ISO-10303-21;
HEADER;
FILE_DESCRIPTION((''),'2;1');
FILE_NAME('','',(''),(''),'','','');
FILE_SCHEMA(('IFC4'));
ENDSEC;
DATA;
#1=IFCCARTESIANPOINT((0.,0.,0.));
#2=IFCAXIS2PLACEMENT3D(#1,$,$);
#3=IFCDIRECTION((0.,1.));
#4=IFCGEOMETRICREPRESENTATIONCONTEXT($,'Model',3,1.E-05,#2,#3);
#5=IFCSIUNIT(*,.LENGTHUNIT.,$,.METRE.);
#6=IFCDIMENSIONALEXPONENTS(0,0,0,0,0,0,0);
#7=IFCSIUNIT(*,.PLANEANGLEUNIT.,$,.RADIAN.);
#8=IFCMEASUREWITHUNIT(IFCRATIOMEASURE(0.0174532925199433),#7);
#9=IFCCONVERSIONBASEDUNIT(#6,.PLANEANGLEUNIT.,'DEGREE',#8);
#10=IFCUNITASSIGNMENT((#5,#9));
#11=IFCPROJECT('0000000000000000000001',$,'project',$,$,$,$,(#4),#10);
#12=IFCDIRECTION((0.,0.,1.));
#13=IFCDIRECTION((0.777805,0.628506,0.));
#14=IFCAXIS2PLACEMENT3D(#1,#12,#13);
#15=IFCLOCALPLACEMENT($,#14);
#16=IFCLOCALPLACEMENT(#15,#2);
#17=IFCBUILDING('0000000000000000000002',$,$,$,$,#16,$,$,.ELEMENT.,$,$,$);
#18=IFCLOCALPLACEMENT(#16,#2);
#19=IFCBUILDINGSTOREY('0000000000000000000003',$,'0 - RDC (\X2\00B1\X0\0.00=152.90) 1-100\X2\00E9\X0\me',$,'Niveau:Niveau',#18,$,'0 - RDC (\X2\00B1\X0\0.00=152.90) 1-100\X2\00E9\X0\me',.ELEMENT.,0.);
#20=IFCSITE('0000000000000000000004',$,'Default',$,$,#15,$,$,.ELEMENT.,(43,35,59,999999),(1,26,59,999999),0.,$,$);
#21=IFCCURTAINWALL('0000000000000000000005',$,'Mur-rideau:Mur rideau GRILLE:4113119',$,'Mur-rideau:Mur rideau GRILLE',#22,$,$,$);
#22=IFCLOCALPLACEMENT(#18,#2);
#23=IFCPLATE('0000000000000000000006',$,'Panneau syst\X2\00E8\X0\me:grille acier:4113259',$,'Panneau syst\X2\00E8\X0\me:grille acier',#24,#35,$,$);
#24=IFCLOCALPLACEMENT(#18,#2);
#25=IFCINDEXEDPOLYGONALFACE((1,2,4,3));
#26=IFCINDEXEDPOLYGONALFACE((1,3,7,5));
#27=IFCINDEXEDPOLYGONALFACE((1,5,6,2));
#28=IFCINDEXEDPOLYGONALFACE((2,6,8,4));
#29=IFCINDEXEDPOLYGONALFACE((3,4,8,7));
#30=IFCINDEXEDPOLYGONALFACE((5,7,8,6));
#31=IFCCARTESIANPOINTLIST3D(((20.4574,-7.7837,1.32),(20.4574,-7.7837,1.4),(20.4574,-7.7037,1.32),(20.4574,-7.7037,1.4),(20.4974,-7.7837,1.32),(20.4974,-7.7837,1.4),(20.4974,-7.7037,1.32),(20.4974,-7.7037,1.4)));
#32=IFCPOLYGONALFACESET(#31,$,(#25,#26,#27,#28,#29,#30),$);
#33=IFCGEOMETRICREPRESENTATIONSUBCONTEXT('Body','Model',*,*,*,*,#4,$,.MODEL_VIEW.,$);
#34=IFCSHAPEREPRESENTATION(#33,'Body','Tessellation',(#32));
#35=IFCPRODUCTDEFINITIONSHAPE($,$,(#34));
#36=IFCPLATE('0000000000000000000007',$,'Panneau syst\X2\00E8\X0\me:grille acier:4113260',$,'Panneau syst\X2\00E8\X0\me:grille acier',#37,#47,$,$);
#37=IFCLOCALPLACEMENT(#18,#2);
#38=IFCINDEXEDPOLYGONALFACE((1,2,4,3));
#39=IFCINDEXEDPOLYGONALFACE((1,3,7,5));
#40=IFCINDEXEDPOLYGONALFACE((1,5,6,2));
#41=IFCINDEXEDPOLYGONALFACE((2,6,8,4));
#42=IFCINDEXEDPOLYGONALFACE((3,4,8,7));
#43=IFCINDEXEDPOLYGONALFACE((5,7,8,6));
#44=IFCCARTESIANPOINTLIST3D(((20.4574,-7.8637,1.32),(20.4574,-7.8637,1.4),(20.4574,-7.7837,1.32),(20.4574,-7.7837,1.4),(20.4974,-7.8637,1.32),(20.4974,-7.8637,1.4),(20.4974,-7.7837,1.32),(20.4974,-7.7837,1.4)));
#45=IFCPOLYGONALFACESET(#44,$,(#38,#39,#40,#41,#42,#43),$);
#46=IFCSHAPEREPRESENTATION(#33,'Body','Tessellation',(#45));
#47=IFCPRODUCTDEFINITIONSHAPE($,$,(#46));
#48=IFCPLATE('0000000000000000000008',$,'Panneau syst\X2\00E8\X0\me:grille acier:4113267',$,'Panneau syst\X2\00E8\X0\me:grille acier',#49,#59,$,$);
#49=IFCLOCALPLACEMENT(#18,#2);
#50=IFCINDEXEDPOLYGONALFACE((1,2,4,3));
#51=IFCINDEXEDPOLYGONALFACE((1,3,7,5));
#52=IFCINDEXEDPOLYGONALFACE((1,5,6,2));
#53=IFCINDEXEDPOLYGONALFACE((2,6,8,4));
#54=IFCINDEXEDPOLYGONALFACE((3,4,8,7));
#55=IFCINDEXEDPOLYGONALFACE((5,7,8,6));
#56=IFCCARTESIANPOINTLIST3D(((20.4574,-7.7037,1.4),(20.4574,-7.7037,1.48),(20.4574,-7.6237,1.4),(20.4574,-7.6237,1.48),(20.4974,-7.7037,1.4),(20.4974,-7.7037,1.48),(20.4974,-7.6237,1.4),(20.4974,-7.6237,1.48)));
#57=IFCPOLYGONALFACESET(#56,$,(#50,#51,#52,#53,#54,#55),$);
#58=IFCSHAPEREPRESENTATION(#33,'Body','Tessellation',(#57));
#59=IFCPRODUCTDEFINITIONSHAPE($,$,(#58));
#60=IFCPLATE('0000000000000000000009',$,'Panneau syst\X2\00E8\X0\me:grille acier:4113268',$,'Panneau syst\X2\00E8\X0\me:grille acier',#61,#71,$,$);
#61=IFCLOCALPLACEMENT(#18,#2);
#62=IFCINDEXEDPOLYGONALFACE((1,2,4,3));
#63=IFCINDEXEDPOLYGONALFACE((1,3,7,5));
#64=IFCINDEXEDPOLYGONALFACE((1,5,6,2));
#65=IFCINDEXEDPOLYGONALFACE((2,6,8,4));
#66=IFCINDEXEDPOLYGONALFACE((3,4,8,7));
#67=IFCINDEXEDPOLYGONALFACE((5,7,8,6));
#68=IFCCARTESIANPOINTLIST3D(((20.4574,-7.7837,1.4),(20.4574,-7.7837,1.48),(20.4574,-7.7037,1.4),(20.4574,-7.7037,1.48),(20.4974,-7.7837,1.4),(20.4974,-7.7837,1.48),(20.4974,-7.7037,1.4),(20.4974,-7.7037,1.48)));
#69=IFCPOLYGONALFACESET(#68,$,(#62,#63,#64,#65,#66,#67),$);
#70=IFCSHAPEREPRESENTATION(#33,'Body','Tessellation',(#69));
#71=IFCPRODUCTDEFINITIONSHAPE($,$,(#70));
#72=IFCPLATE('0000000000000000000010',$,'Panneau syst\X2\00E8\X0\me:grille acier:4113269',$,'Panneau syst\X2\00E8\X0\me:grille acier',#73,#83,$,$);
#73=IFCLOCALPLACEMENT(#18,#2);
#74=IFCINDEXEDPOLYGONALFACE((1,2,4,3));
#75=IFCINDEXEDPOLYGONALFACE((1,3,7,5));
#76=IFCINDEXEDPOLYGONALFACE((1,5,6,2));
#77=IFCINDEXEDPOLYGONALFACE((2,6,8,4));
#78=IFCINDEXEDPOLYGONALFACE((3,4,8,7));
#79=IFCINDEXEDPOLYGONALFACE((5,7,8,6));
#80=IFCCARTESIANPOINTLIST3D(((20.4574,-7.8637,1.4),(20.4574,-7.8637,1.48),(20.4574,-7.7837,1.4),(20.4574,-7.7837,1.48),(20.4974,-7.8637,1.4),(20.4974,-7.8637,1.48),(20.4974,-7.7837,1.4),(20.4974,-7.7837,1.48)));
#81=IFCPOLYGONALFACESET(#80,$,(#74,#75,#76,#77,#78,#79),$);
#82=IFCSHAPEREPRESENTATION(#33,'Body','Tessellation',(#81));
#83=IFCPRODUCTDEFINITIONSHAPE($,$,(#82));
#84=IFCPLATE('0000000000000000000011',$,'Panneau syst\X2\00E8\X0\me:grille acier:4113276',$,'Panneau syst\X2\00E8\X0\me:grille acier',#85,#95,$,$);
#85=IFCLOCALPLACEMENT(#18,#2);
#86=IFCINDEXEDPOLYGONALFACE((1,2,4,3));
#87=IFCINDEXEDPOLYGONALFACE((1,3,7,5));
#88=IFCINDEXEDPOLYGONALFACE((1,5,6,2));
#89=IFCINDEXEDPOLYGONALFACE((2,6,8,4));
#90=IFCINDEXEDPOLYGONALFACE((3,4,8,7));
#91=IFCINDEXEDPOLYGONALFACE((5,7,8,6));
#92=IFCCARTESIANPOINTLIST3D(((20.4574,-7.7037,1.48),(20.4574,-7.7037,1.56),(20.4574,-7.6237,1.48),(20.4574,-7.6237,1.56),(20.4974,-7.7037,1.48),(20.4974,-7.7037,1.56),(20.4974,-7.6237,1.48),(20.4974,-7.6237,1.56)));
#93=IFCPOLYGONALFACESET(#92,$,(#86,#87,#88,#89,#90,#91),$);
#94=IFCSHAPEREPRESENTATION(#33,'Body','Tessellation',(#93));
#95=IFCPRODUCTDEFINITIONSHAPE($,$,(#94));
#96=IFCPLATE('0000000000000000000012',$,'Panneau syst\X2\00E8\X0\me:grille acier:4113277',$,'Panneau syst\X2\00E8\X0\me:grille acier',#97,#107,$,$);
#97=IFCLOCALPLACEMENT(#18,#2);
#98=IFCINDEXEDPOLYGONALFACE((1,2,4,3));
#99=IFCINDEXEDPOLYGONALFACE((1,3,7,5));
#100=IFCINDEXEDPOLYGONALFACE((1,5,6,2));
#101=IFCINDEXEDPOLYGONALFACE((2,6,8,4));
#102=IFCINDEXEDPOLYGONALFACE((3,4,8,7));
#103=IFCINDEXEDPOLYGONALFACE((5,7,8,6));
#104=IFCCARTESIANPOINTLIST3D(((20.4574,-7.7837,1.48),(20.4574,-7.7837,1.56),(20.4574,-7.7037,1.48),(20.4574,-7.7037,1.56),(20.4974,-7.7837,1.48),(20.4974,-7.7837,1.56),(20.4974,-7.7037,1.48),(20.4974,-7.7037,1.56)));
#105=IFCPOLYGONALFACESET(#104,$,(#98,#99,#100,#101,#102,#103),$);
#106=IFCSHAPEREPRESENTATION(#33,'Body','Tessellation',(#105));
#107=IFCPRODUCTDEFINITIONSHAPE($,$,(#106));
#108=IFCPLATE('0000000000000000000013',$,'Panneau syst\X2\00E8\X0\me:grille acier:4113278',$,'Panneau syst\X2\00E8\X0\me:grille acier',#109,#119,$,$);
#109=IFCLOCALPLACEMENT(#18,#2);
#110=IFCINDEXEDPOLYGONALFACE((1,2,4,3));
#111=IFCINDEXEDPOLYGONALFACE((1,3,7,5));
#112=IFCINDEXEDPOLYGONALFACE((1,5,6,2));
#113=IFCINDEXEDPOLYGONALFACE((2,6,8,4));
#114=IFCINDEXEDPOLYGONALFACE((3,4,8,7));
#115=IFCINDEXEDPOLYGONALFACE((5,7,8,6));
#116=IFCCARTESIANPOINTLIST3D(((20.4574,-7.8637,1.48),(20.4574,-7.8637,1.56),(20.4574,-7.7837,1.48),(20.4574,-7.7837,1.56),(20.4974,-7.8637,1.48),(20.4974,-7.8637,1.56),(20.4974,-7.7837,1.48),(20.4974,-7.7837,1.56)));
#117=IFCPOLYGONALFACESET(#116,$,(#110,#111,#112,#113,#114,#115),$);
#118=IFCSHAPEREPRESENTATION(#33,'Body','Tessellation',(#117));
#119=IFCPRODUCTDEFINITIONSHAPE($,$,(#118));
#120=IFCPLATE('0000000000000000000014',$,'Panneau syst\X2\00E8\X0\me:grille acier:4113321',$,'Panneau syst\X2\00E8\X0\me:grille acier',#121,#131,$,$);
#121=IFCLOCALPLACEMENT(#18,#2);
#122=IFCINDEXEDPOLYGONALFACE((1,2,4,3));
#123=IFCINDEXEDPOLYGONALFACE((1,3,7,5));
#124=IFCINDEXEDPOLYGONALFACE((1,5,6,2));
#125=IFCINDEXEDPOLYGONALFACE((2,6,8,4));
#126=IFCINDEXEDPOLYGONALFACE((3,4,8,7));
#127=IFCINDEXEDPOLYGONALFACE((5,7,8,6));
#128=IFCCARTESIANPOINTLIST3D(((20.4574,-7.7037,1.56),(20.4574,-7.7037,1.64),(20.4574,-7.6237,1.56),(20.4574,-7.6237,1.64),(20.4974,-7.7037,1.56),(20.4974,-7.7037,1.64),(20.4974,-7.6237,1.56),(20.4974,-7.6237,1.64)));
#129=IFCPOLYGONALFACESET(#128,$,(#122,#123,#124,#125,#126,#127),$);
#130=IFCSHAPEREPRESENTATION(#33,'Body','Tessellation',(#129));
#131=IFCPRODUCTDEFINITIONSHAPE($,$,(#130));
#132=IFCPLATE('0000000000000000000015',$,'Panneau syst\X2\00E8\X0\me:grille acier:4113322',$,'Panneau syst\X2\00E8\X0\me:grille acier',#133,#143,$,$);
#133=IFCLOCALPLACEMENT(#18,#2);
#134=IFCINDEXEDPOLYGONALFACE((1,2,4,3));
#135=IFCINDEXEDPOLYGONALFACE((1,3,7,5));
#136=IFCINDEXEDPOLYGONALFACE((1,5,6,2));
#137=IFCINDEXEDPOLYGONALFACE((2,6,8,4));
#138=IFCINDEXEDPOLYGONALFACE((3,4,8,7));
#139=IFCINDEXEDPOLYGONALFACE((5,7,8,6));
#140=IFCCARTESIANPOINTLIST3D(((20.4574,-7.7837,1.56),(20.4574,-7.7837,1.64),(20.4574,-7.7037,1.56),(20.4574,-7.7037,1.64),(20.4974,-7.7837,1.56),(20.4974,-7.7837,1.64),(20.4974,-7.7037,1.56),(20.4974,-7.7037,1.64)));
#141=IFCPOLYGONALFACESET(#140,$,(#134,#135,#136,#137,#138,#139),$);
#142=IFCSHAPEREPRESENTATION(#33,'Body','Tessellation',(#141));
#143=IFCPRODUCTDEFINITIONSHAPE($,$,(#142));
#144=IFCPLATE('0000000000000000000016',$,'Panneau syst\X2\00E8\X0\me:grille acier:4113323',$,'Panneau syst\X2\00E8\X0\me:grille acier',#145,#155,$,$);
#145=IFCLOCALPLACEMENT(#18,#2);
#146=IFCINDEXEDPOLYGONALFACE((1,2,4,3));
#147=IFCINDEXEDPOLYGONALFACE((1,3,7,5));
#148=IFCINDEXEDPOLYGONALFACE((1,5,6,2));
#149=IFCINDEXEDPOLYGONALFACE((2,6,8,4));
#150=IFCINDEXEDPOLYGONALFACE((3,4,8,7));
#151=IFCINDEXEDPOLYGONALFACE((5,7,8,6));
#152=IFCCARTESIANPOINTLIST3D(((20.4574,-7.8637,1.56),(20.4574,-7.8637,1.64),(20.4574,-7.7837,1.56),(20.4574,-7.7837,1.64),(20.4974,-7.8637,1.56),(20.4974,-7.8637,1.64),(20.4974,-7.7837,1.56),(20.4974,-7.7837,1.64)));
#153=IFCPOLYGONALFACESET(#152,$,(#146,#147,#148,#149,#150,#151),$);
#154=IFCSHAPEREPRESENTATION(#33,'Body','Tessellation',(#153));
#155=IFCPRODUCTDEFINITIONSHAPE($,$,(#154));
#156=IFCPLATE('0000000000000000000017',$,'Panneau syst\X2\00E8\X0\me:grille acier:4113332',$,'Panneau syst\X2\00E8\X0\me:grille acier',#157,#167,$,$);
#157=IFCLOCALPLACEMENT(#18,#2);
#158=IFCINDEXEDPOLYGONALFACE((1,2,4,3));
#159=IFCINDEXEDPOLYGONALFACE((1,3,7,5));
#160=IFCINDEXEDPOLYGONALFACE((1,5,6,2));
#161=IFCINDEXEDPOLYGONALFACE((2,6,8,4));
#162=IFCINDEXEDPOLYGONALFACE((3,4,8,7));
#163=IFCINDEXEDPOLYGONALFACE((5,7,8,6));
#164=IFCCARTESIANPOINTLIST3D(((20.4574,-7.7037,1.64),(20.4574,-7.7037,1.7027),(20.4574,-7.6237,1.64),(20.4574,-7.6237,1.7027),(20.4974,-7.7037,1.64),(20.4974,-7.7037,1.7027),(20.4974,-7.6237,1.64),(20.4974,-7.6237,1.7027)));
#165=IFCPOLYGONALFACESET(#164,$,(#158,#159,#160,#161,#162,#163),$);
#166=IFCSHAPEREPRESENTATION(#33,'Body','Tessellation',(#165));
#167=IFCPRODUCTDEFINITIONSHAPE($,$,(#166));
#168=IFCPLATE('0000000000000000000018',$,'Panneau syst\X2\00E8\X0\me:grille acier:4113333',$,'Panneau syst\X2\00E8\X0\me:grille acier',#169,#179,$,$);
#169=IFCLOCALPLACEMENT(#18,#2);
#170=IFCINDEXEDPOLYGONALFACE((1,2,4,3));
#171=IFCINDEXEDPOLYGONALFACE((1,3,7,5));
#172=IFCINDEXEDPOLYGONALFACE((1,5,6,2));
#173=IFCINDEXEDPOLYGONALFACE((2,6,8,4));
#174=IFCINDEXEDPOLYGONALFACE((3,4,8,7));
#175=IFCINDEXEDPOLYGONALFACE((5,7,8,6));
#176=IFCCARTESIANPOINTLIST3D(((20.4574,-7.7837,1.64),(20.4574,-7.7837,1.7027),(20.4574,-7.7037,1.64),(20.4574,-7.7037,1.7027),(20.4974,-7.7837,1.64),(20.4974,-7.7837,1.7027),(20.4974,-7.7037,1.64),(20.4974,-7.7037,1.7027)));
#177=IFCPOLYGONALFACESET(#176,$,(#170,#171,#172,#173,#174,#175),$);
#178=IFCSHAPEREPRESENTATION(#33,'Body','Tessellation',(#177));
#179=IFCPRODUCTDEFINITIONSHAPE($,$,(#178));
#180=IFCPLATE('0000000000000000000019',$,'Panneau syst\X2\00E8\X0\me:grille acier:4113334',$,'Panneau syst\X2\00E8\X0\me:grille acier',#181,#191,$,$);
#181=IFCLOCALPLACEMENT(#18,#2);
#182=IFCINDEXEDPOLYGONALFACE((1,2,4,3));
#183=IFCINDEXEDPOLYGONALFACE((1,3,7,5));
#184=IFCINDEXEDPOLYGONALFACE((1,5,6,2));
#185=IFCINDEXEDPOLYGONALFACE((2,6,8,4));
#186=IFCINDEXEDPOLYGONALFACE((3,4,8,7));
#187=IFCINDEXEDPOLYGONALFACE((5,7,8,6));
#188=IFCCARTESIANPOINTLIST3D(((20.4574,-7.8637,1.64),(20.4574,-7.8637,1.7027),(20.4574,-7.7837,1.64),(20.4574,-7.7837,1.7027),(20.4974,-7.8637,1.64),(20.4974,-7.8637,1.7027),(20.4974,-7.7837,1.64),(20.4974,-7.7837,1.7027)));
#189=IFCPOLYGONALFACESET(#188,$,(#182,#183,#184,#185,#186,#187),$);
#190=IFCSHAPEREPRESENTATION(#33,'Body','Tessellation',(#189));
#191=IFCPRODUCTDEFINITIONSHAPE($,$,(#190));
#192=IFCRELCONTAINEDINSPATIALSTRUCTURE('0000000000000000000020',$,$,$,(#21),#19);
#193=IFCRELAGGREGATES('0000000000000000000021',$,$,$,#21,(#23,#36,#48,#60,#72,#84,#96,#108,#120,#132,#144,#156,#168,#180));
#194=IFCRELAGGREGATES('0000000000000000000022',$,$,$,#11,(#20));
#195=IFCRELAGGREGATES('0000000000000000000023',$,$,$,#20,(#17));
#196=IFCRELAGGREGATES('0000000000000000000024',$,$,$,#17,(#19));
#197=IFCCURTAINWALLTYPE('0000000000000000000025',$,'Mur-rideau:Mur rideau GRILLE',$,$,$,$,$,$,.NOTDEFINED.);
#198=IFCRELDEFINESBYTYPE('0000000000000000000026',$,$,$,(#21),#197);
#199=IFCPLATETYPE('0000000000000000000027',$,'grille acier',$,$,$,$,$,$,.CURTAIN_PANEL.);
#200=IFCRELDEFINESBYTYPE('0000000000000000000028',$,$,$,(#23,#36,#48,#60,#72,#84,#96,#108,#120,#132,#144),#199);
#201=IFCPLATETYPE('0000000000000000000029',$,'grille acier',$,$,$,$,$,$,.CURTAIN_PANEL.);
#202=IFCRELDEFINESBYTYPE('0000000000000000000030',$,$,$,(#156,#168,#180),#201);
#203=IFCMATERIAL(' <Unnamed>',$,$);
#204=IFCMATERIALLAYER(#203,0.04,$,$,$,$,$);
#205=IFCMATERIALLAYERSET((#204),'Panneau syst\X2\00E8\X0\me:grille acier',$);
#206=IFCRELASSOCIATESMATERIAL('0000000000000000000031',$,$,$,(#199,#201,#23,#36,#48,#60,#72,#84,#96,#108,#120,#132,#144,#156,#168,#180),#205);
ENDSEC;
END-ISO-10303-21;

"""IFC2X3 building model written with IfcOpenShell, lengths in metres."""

from ifc_helpers import new_model, entity, si_unit, converted_unit, direction, frame, origin, origin_2d_with_axis, place, context, subcontext, project, spatial, rectangle, extrude, source, transform, mapped, material, layer, layer_set, layer_usage, type_object, type_shapes, element, aggregate, save


model = new_model("IFC2X3")

# Units and contexts
model_context = context("Model", 3, precision=1e-05, world=origin(), true_north=direction((0.0, 1.0)))
body_context = subcontext(model_context, "Body", "Model", "MODEL_VIEW")
ifc_project = project(units=[si_unit("LENGTHUNIT", "METRE"), converted_unit("PLANEANGLEUNIT", "DEGREE", entity("IfcRatioMeasure", 0.0174532925199433), si_unit("PLANEANGLEUNIT", "RADIAN"), dimensions=[0, 0, 0, 0, 0, 0, 0])], contexts=[model_context])

# Site, building, storey
site_placement = place(None, frame((0.0, 0.0, 0.0), z_axis=(0.0, 0.0, 1.0), x_axis=(0.777805, 0.628506, 0.0)))
site = spatial("IfcSite", under=ifc_project, at=site_placement, Name="Default", CompositionType="ELEMENT", RefLatitude=(43, 35, 59, 999999), RefLongitude=(1, 26, 59, 999999), RefElevation=0.0)
building_placement = place(site_placement, origin())
building = spatial("IfcBuilding", under=site, at=building_placement, CompositionType="ELEMENT")
storey_placement = place(building_placement, origin())
storey = spatial("IfcBuildingStorey", under=building, at=storey_placement, Name="0 - RDC (±0.00=152.90) 1-100éme", ObjectType="Niveau:Niveau", LongName="0 - RDC (±0.00=152.90) 1-100éme", CompositionType="ELEMENT", Elevation=0.0)

# Curtain wall, plates
curtain_wall_type = type_object("IfcCurtainWallType", Name="Mur-rideau:Mur rideau GRILLE", PredefinedType="NOTDEFINED")
curtain_wall_placement = place(storey_placement, origin())
curtain_wall = element("IfcCurtainWall", 1, at=curtain_wall_placement, inside=storey, type_object=curtain_wall_type, Name="Mur-rideau:Mur rideau GRILLE:4113119", ObjectType="Mur-rideau:Mur rideau GRILLE")
ifc_material = material(Name=" <Unnamed>")
ifc_layer = layer(ifc_material, 0.04)
ifc_layer_set = layer_set([ifc_layer], Name="Panneau système:grille acier")
plate_type_1 = type_object("IfcPlateType", Name="grille acier", PredefinedType="CURTAIN_PANEL", material=ifc_layer_set)
shared_shape_1 = source(origin(), body_context, "Body", "SweptSolid", [
    extrude(rectangle(XDim=0.04, YDim=0.08, at=origin_2d_with_axis()), frame((0.0, 0.0, 0.0), z_axis=(0.0, 0.0, 1.0), x_axis=(0.0, 1.0, 0.0)), (0.0, 0.0, 1.0), 0.08),
])
type_shapes(plate_type_1, [shared_shape_1])
ifc_layer_usage_1 = layer_usage(ifc_layer_set, "AXIS3", "POSITIVE", 0.0)
plate_1_placement = place(curtain_wall_placement, frame((20.4774, -7.7437, 1.32), z_axis=(0.0, 0.0, 1.0), x_axis=(0.0, -1.0, 0.0)))
plate_1 = element("IfcPlate", 2, at=plate_1_placement, type_object=plate_type_1, material=ifc_layer_usage_1, Name="Panneau système:grille acier:4113259", ObjectType="Panneau système:grille acier", context=body_context, shape_type="MappedRepresentation", body=[
    mapped(shared_shape_1, transform((0.0, 0.0, 0.0), scale=1.0)),
])
ifc_layer_usage_2 = layer_usage(ifc_layer_set, "AXIS3", "POSITIVE", 0.0)
plate_2_placement = place(curtain_wall_placement, frame((20.4774, -7.8237, 1.32), z_axis=(0.0, 0.0, 1.0), x_axis=(0.0, -1.0, 0.0)))
plate_2 = element("IfcPlate", 3, at=plate_2_placement, type_object=plate_type_1, material=ifc_layer_usage_2, Name="Panneau système:grille acier:4113260", ObjectType="Panneau système:grille acier", context=body_context, shape_type="MappedRepresentation", body=[
    mapped(shared_shape_1, transform((0.0, 0.0, 0.0), scale=1.0)),
])
ifc_layer_usage_3 = layer_usage(ifc_layer_set, "AXIS3", "POSITIVE", 0.0)
plate_3_placement = place(curtain_wall_placement, frame((20.4774, -7.6637, 1.4), z_axis=(0.0, 0.0, 1.0), x_axis=(0.0, -1.0, 0.0)))
plate_3 = element("IfcPlate", 4, at=plate_3_placement, type_object=plate_type_1, material=ifc_layer_usage_3, Name="Panneau système:grille acier:4113267", ObjectType="Panneau système:grille acier", context=body_context, shape_type="MappedRepresentation", body=[
    mapped(shared_shape_1, transform((0.0, 0.0, 0.0), scale=1.0)),
])
ifc_layer_usage_4 = layer_usage(ifc_layer_set, "AXIS3", "POSITIVE", 0.0)
plate_4_placement = place(curtain_wall_placement, frame((20.4774, -7.7437, 1.4), z_axis=(0.0, 0.0, 1.0), x_axis=(0.0, -1.0, 0.0)))
plate_4 = element("IfcPlate", 5, at=plate_4_placement, type_object=plate_type_1, material=ifc_layer_usage_4, Name="Panneau système:grille acier:4113268", ObjectType="Panneau système:grille acier", context=body_context, shape_type="MappedRepresentation", body=[
    mapped(shared_shape_1, transform((0.0, 0.0, 0.0), scale=1.0)),
])
ifc_layer_usage_5 = layer_usage(ifc_layer_set, "AXIS3", "POSITIVE", 0.0)
plate_5_placement = place(curtain_wall_placement, frame((20.4774, -7.8237, 1.4), z_axis=(0.0, 0.0, 1.0), x_axis=(0.0, -1.0, 0.0)))
plate_5 = element("IfcPlate", 6, at=plate_5_placement, type_object=plate_type_1, material=ifc_layer_usage_5, Name="Panneau système:grille acier:4113269", ObjectType="Panneau système:grille acier", context=body_context, shape_type="MappedRepresentation", body=[
    mapped(shared_shape_1, transform((0.0, 0.0, 0.0), scale=1.0)),
])
ifc_layer_usage_6 = layer_usage(ifc_layer_set, "AXIS3", "POSITIVE", 0.0)
plate_6_placement = place(curtain_wall_placement, frame((20.4774, -7.6637, 1.48), z_axis=(0.0, 0.0, 1.0), x_axis=(0.0, -1.0, 0.0)))
plate_6 = element("IfcPlate", 7, at=plate_6_placement, type_object=plate_type_1, material=ifc_layer_usage_6, Name="Panneau système:grille acier:4113276", ObjectType="Panneau système:grille acier", context=body_context, shape_type="MappedRepresentation", body=[
    mapped(shared_shape_1, transform((0.0, 0.0, 0.0), scale=1.0)),
])
ifc_layer_usage_7 = layer_usage(ifc_layer_set, "AXIS3", "POSITIVE", 0.0)
plate_7_placement = place(curtain_wall_placement, frame((20.4774, -7.7437, 1.48), z_axis=(0.0, 0.0, 1.0), x_axis=(0.0, -1.0, 0.0)))
plate_7 = element("IfcPlate", 8, at=plate_7_placement, type_object=plate_type_1, material=ifc_layer_usage_7, Name="Panneau système:grille acier:4113277", ObjectType="Panneau système:grille acier", context=body_context, shape_type="MappedRepresentation", body=[
    mapped(shared_shape_1, transform((0.0, 0.0, 0.0), scale=1.0)),
])
ifc_layer_usage_8 = layer_usage(ifc_layer_set, "AXIS3", "POSITIVE", 0.0)
plate_8_placement = place(curtain_wall_placement, frame((20.4774, -7.8237, 1.48), z_axis=(0.0, 0.0, 1.0), x_axis=(0.0, -1.0, 0.0)))
plate_8 = element("IfcPlate", 9, at=plate_8_placement, type_object=plate_type_1, material=ifc_layer_usage_8, Name="Panneau système:grille acier:4113278", ObjectType="Panneau système:grille acier", context=body_context, shape_type="MappedRepresentation", body=[
    mapped(shared_shape_1, transform((0.0, 0.0, 0.0), scale=1.0)),
])
ifc_layer_usage_9 = layer_usage(ifc_layer_set, "AXIS3", "POSITIVE", 0.0)
plate_9_placement = place(curtain_wall_placement, frame((20.4774, -7.6637, 1.56), z_axis=(0.0, 0.0, 1.0), x_axis=(0.0, -1.0, 0.0)))
plate_9 = element("IfcPlate", 10, at=plate_9_placement, type_object=plate_type_1, material=ifc_layer_usage_9, Name="Panneau système:grille acier:4113321", ObjectType="Panneau système:grille acier", context=body_context, shape_type="MappedRepresentation", body=[
    mapped(shared_shape_1, transform((0.0, 0.0, 0.0), scale=1.0)),
])
ifc_layer_usage_10 = layer_usage(ifc_layer_set, "AXIS3", "POSITIVE", 0.0)
plate_10_placement = place(curtain_wall_placement, frame((20.4774, -7.7437, 1.56), z_axis=(0.0, 0.0, 1.0), x_axis=(0.0, -1.0, 0.0)))
plate_10 = element("IfcPlate", 11, at=plate_10_placement, type_object=plate_type_1, material=ifc_layer_usage_10, Name="Panneau système:grille acier:4113322", ObjectType="Panneau système:grille acier", context=body_context, shape_type="MappedRepresentation", body=[
    mapped(shared_shape_1, transform((0.0, 0.0, 0.0), scale=1.0)),
])
ifc_layer_usage_11 = layer_usage(ifc_layer_set, "AXIS3", "POSITIVE", 0.0)
plate_11_placement = place(curtain_wall_placement, frame((20.4774, -7.8237, 1.56), z_axis=(0.0, 0.0, 1.0), x_axis=(0.0, -1.0, 0.0)))
plate_11 = element("IfcPlate", 12, at=plate_11_placement, type_object=plate_type_1, material=ifc_layer_usage_11, Name="Panneau système:grille acier:4113323", ObjectType="Panneau système:grille acier", context=body_context, shape_type="MappedRepresentation", body=[
    mapped(shared_shape_1, transform((0.0, 0.0, 0.0), scale=1.0)),
])
ifc_layer_usage_12 = layer_usage(ifc_layer_set, "AXIS3", "POSITIVE", 0.0)
plate_type_2 = type_object("IfcPlateType", Name="grille acier", PredefinedType="CURTAIN_PANEL", material=ifc_layer_set)
shared_shape_2 = source(origin(), body_context, "Body", "SweptSolid", [
    extrude(rectangle(XDim=0.04, YDim=0.08, at=origin_2d_with_axis()), frame((0.0, 0.0, 0.0), z_axis=(0.0, 0.0, 1.0), x_axis=(0.0, 1.0, 0.0)), (0.0, 0.0, 1.0), 0.0627),
])
type_shapes(plate_type_2, [shared_shape_2])
plate_12_placement = place(curtain_wall_placement, frame((20.4774, -7.6637, 1.64), z_axis=(0.0, 0.0, 1.0), x_axis=(0.0, -1.0, 0.0)))
plate_12 = element("IfcPlate", 13, at=plate_12_placement, type_object=plate_type_2, material=ifc_layer_usage_12, Name="Panneau système:grille acier:4113332", ObjectType="Panneau système:grille acier", context=body_context, shape_type="MappedRepresentation", body=[
    mapped(shared_shape_2, transform((0.0, 0.0, 0.0), scale=1.0)),
])
ifc_layer_usage_13 = layer_usage(ifc_layer_set, "AXIS3", "POSITIVE", 0.0)
plate_13_placement = place(curtain_wall_placement, frame((20.4774, -7.7437, 1.64), z_axis=(0.0, 0.0, 1.0), x_axis=(0.0, -1.0, 0.0)))
plate_13 = element("IfcPlate", 14, at=plate_13_placement, type_object=plate_type_2, material=ifc_layer_usage_13, Name="Panneau système:grille acier:4113333", ObjectType="Panneau système:grille acier", context=body_context, shape_type="MappedRepresentation", body=[
    mapped(shared_shape_2, transform((0.0, 0.0, 0.0), scale=1.0)),
])
ifc_layer_usage_14 = layer_usage(ifc_layer_set, "AXIS3", "POSITIVE", 0.0)
plate_14_placement = place(curtain_wall_placement, frame((20.4774, -7.8237, 1.64), z_axis=(0.0, 0.0, 1.0), x_axis=(0.0, -1.0, 0.0)))
plate_14 = element("IfcPlate", 15, at=plate_14_placement, type_object=plate_type_2, material=ifc_layer_usage_14, Name="Panneau système:grille acier:4113334", ObjectType="Panneau système:grille acier", context=body_context, shape_type="MappedRepresentation", body=[
    mapped(shared_shape_2, transform((0.0, 0.0, 0.0), scale=1.0)),
])
aggregate(curtain_wall, [plate_1, plate_2, plate_3, plate_4, plate_5, plate_6, plate_7, plate_8, plate_9, plate_10, plate_11, plate_12, plate_13, plate_14])

save(model, "model.ifc")
